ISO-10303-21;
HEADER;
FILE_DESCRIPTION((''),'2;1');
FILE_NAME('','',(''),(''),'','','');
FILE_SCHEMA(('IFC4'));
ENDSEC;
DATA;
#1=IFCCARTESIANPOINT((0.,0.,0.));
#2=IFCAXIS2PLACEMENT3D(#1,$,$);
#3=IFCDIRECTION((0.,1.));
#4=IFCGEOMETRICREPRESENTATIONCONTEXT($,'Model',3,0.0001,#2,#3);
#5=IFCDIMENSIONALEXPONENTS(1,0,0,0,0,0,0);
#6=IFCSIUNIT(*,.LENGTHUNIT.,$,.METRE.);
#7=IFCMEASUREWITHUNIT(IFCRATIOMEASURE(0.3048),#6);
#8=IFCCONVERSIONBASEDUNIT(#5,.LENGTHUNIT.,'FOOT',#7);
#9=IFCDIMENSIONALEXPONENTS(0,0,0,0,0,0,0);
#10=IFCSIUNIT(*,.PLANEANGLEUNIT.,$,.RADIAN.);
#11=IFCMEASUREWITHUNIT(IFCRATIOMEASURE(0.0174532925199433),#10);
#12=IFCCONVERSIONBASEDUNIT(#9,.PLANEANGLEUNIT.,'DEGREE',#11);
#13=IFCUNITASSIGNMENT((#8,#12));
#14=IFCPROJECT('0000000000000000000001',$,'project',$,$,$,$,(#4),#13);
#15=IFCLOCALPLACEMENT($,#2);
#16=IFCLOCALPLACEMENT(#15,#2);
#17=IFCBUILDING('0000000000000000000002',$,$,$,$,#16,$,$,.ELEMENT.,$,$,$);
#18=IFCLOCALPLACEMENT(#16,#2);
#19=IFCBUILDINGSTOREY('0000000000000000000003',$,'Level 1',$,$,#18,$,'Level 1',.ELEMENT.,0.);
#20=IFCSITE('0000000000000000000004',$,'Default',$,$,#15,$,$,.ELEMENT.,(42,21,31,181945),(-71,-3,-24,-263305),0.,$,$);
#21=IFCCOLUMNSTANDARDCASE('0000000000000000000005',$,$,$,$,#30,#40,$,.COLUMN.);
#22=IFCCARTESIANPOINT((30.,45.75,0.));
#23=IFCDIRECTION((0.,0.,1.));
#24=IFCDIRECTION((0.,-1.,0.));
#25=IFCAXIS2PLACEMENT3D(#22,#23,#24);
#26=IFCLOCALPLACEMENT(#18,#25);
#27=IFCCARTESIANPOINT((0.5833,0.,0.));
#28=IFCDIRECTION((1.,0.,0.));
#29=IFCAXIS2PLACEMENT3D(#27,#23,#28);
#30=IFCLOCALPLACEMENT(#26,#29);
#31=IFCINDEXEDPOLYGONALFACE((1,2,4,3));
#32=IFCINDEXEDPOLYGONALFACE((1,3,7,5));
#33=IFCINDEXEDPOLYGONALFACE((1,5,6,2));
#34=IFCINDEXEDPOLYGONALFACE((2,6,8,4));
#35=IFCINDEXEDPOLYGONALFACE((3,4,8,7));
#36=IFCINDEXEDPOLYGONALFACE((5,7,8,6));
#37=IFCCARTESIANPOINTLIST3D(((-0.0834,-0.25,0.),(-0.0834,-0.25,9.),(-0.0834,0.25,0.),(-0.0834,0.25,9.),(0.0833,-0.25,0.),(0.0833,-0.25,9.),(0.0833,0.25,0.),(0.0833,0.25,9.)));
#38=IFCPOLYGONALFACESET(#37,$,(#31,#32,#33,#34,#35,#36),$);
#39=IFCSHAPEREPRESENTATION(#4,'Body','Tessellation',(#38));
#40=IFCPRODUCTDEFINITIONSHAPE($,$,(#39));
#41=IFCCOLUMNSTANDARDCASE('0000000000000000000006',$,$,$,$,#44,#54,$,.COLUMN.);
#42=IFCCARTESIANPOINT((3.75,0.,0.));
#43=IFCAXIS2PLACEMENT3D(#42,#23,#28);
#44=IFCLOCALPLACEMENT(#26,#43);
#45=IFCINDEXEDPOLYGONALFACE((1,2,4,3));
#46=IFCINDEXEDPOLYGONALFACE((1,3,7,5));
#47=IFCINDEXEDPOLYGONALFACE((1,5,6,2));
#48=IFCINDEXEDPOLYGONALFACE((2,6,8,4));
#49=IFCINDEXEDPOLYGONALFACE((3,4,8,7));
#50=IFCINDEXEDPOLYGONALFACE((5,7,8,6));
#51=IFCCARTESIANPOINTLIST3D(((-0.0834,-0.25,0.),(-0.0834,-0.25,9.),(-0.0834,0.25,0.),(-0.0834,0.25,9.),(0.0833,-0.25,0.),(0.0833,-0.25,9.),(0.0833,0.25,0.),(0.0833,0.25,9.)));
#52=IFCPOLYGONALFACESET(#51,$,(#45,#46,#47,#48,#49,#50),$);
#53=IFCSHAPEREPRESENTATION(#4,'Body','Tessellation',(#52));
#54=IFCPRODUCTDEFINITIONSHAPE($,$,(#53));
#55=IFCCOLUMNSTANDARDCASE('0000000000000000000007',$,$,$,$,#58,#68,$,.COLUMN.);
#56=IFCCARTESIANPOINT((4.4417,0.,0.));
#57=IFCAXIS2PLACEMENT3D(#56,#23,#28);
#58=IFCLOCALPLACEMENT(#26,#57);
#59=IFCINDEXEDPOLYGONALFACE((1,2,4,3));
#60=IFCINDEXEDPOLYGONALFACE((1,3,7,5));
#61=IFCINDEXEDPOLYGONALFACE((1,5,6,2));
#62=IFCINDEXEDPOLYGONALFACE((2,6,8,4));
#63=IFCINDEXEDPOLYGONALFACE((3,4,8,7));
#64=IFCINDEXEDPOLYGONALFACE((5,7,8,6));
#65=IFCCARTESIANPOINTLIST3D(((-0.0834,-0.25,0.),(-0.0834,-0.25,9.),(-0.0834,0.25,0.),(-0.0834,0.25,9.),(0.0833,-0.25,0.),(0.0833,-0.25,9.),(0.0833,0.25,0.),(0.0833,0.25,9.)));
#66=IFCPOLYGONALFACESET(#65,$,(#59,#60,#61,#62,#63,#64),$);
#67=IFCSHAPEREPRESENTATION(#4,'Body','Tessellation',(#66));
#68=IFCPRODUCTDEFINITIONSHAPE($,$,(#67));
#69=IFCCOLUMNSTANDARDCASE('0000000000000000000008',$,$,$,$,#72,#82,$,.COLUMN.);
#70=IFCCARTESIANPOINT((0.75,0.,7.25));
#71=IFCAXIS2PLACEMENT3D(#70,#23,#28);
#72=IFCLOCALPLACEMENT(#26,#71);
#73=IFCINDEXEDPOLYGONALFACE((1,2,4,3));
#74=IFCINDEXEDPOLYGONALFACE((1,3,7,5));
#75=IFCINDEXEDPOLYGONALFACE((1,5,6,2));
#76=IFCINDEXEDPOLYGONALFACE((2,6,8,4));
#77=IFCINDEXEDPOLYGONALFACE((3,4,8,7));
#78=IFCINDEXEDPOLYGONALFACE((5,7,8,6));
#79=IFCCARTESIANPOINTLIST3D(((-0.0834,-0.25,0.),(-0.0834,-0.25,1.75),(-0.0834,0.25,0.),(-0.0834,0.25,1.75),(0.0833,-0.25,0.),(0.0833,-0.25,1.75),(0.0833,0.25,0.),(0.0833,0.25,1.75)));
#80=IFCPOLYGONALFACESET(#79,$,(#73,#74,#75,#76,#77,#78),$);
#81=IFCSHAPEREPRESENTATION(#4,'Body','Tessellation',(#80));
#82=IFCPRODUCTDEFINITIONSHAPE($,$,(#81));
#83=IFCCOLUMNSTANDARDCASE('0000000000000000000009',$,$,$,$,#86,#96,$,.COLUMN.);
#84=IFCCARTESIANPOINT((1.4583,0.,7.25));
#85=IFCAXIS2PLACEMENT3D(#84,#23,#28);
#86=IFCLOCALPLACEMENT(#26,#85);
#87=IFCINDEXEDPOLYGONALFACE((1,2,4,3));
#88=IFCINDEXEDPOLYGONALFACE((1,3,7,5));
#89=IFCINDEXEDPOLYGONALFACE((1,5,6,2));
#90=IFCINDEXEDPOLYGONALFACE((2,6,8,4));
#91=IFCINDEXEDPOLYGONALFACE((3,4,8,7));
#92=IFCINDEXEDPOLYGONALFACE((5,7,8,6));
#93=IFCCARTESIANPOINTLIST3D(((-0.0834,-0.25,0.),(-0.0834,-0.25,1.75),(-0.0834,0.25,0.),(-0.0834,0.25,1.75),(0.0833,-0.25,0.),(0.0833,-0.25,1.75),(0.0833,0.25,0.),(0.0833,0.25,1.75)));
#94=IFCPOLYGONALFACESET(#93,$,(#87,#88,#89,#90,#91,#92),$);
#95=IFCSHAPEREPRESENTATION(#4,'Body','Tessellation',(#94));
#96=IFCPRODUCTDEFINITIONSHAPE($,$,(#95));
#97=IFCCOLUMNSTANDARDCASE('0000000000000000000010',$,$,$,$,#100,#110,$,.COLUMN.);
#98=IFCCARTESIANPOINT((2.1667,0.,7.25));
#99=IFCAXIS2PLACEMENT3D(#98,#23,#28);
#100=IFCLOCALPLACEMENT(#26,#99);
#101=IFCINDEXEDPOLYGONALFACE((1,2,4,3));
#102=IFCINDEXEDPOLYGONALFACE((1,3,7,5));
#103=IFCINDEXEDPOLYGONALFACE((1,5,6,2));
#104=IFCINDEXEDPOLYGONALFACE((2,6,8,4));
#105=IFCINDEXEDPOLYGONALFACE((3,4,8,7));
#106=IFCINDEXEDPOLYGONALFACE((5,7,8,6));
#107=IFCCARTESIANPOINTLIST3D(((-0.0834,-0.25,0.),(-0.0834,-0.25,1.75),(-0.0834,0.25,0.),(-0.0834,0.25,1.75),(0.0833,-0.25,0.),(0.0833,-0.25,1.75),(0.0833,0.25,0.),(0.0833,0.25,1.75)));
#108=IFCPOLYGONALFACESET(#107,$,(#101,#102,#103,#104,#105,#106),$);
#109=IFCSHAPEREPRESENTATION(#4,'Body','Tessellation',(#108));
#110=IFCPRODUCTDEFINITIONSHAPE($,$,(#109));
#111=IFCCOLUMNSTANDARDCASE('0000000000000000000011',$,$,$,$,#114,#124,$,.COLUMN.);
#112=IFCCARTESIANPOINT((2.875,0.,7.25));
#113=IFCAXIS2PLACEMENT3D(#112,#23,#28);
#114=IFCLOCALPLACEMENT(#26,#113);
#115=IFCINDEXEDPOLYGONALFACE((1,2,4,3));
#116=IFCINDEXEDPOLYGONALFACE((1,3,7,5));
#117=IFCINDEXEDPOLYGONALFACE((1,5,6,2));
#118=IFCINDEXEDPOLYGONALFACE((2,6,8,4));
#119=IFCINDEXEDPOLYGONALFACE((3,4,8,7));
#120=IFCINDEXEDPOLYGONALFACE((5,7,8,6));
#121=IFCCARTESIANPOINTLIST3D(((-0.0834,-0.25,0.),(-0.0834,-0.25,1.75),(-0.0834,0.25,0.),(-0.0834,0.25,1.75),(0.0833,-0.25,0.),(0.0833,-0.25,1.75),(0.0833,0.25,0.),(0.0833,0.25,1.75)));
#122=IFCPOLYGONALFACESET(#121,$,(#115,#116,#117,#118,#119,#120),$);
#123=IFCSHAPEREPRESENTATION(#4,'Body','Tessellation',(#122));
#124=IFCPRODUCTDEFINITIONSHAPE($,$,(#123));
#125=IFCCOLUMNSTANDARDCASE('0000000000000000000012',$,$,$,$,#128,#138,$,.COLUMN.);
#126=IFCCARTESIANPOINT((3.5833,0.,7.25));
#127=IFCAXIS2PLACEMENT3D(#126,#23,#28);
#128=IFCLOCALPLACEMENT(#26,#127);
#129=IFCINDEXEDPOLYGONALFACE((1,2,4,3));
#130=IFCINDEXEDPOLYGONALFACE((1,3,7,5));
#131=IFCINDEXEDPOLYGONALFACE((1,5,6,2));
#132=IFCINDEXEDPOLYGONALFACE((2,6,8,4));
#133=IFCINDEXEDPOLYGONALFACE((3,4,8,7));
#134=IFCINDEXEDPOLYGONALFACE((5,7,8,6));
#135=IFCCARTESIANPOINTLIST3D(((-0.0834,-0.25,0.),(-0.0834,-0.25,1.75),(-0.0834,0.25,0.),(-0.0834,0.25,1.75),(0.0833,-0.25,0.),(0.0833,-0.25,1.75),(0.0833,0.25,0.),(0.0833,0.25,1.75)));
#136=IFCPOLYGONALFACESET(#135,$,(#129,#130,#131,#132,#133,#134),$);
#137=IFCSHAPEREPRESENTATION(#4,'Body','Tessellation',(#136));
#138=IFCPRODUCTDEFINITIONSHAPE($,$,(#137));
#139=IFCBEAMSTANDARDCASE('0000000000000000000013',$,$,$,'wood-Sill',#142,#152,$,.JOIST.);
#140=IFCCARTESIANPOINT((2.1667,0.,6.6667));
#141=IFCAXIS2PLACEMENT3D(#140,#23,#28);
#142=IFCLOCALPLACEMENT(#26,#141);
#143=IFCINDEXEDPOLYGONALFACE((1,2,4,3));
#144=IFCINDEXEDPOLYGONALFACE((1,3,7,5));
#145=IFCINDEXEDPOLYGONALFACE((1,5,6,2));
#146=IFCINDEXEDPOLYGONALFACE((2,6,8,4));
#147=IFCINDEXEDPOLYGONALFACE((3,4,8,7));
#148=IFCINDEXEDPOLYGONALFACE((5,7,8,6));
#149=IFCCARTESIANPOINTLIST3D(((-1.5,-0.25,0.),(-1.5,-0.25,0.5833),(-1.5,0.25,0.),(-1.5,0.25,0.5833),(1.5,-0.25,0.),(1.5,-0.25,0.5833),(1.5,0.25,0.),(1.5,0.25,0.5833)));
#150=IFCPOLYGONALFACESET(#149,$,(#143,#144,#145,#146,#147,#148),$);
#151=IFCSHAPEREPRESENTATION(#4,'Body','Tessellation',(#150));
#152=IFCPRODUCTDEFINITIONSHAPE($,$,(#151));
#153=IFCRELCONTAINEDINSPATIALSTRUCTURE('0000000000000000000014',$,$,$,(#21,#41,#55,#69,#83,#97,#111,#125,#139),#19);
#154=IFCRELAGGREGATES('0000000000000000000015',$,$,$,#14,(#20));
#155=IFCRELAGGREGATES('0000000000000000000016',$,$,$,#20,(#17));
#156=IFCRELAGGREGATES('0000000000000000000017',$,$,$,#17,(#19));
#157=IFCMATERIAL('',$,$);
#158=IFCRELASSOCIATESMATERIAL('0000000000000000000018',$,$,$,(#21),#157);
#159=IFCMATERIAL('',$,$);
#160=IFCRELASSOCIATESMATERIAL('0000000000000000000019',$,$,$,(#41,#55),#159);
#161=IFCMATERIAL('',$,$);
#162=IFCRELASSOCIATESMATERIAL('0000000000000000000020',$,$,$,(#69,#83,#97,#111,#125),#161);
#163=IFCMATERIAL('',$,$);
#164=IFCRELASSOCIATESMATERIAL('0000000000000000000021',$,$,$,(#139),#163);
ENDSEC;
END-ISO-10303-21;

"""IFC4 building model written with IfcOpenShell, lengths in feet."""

from ifc_helpers import new_model, entity, si_unit, converted_unit, direction, frame, origin, place, context, project, spatial, rectangle, extrude, material, element, save


model = new_model("IFC4")

# Units and contexts
model_context = context("Model", 3, precision=0.0001, world=origin(), true_north=direction((0.0, 1.0)))
ifc_project = project(units=[converted_unit("LENGTHUNIT", "FOOT", entity("IfcRatioMeasure", 0.3048), si_unit("LENGTHUNIT", "METRE"), dimensions=[1, 0, 0, 0, 0, 0, 0]), converted_unit("PLANEANGLEUNIT", "DEGREE", entity("IfcRatioMeasure", 0.0174532925199433), si_unit("PLANEANGLEUNIT", "RADIAN"), dimensions=[0, 0, 0, 0, 0, 0, 0])], contexts=[model_context])

# Site, building, storey
site_placement = place(None, origin())
site = spatial("IfcSite", under=ifc_project, at=site_placement, Name="Default", CompositionType="ELEMENT", RefLatitude=(42, 21, 31, 181945), RefLongitude=(-71, -3, -24, -263305), RefElevation=0.0)
building_placement = place(site_placement, origin())
building = spatial("IfcBuilding", under=site, at=building_placement, CompositionType="ELEMENT")
storey_placement = place(building_placement, origin())
storey = spatial("IfcBuildingStorey", under=building, at=storey_placement, Name="Level 1", LongName="Level 1", CompositionType="ELEMENT", Elevation=0.0)

# Columns
ifc_material_1 = material(Name="")
ifc_material_2 = material(Name="")
ifc_material_3 = material(Name="")
placement_1 = place(storey_placement, frame((30.0, 45.75, 0.0), z_axis=(0.0, 0.0, 1.0), x_axis=(0.0, -1.0, 0.0)))
for number, where, z_axis, x_axis in (
    (1, (0.5833, 0.0, 0.0), (0.0, 0.0, 1.0), (1.0, 0.0, 0.0)),
):
    element("IfcColumnStandardCase", number, at=place(placement_1, frame(where, z_axis=z_axis, x_axis=x_axis)), inside=storey, material=ifc_material_3, PredefinedType="COLUMN", context=model_context, shape_type="SweptSolid", body=[
        extrude(rectangle(XDim=0.1667, YDim=0.5), origin(), (0.0, 0.0, 1.0), 9.0),
    ])
for number, where, z_axis, x_axis in (
    (2, (3.75, 0.0, 0.0), (0.0, 0.0, 1.0), (1.0, 0.0, 0.0)),
    (3, (4.4417, 0.0, 0.0), (0.0, 0.0, 1.0), (1.0, 0.0, 0.0)),
):
    element("IfcColumnStandardCase", number, at=place(placement_1, frame(where, z_axis=z_axis, x_axis=x_axis)), inside=storey, material=ifc_material_1, PredefinedType="COLUMN", context=model_context, shape_type="SweptSolid", body=[
        extrude(rectangle(XDim=0.1667, YDim=0.5), origin(), (0.0, 0.0, 1.0), 9.0),
    ])
for number, where, z_axis, x_axis in (
    (4, (0.75, 0.0, 7.25), (0.0, 0.0, 1.0), (1.0, 0.0, 0.0)),
    (5, (1.4583, 0.0, 7.25), (0.0, 0.0, 1.0), (1.0, 0.0, 0.0)),
    (6, (2.1667, 0.0, 7.25), (0.0, 0.0, 1.0), (1.0, 0.0, 0.0)),
    (7, (2.875, 0.0, 7.25), (0.0, 0.0, 1.0), (1.0, 0.0, 0.0)),
    (8, (3.5833, 0.0, 7.25), (0.0, 0.0, 1.0), (1.0, 0.0, 0.0)),
):
    element("IfcColumnStandardCase", number, at=place(placement_1, frame(where, z_axis=z_axis, x_axis=x_axis)), inside=storey, material=ifc_material_2, PredefinedType="COLUMN", context=model_context, shape_type="SweptSolid", body=[
        extrude(rectangle(XDim=0.1667, YDim=0.5), origin(), (0.0, 0.0, 1.0), 1.75),
    ])

# Beam
ifc_material_4 = material(Name="")
for number, where, z_axis, x_axis in (
    (9, (2.1667, 0.0, 6.6667), (0.0, 0.0, 1.0), (1.0, 0.0, 0.0)),
):
    element("IfcBeamStandardCase", number, at=place(placement_1, frame(where, z_axis=z_axis, x_axis=x_axis)), inside=storey, material=ifc_material_4, ObjectType="wood-Sill", PredefinedType="JOIST", context=model_context, shape_type="SweptSolid", body=[
        extrude(rectangle(XDim=3.0, YDim=0.5), origin(), (0.0, 0.0, 1.0), 0.5833),
    ])

save(model, "model.ifc")
